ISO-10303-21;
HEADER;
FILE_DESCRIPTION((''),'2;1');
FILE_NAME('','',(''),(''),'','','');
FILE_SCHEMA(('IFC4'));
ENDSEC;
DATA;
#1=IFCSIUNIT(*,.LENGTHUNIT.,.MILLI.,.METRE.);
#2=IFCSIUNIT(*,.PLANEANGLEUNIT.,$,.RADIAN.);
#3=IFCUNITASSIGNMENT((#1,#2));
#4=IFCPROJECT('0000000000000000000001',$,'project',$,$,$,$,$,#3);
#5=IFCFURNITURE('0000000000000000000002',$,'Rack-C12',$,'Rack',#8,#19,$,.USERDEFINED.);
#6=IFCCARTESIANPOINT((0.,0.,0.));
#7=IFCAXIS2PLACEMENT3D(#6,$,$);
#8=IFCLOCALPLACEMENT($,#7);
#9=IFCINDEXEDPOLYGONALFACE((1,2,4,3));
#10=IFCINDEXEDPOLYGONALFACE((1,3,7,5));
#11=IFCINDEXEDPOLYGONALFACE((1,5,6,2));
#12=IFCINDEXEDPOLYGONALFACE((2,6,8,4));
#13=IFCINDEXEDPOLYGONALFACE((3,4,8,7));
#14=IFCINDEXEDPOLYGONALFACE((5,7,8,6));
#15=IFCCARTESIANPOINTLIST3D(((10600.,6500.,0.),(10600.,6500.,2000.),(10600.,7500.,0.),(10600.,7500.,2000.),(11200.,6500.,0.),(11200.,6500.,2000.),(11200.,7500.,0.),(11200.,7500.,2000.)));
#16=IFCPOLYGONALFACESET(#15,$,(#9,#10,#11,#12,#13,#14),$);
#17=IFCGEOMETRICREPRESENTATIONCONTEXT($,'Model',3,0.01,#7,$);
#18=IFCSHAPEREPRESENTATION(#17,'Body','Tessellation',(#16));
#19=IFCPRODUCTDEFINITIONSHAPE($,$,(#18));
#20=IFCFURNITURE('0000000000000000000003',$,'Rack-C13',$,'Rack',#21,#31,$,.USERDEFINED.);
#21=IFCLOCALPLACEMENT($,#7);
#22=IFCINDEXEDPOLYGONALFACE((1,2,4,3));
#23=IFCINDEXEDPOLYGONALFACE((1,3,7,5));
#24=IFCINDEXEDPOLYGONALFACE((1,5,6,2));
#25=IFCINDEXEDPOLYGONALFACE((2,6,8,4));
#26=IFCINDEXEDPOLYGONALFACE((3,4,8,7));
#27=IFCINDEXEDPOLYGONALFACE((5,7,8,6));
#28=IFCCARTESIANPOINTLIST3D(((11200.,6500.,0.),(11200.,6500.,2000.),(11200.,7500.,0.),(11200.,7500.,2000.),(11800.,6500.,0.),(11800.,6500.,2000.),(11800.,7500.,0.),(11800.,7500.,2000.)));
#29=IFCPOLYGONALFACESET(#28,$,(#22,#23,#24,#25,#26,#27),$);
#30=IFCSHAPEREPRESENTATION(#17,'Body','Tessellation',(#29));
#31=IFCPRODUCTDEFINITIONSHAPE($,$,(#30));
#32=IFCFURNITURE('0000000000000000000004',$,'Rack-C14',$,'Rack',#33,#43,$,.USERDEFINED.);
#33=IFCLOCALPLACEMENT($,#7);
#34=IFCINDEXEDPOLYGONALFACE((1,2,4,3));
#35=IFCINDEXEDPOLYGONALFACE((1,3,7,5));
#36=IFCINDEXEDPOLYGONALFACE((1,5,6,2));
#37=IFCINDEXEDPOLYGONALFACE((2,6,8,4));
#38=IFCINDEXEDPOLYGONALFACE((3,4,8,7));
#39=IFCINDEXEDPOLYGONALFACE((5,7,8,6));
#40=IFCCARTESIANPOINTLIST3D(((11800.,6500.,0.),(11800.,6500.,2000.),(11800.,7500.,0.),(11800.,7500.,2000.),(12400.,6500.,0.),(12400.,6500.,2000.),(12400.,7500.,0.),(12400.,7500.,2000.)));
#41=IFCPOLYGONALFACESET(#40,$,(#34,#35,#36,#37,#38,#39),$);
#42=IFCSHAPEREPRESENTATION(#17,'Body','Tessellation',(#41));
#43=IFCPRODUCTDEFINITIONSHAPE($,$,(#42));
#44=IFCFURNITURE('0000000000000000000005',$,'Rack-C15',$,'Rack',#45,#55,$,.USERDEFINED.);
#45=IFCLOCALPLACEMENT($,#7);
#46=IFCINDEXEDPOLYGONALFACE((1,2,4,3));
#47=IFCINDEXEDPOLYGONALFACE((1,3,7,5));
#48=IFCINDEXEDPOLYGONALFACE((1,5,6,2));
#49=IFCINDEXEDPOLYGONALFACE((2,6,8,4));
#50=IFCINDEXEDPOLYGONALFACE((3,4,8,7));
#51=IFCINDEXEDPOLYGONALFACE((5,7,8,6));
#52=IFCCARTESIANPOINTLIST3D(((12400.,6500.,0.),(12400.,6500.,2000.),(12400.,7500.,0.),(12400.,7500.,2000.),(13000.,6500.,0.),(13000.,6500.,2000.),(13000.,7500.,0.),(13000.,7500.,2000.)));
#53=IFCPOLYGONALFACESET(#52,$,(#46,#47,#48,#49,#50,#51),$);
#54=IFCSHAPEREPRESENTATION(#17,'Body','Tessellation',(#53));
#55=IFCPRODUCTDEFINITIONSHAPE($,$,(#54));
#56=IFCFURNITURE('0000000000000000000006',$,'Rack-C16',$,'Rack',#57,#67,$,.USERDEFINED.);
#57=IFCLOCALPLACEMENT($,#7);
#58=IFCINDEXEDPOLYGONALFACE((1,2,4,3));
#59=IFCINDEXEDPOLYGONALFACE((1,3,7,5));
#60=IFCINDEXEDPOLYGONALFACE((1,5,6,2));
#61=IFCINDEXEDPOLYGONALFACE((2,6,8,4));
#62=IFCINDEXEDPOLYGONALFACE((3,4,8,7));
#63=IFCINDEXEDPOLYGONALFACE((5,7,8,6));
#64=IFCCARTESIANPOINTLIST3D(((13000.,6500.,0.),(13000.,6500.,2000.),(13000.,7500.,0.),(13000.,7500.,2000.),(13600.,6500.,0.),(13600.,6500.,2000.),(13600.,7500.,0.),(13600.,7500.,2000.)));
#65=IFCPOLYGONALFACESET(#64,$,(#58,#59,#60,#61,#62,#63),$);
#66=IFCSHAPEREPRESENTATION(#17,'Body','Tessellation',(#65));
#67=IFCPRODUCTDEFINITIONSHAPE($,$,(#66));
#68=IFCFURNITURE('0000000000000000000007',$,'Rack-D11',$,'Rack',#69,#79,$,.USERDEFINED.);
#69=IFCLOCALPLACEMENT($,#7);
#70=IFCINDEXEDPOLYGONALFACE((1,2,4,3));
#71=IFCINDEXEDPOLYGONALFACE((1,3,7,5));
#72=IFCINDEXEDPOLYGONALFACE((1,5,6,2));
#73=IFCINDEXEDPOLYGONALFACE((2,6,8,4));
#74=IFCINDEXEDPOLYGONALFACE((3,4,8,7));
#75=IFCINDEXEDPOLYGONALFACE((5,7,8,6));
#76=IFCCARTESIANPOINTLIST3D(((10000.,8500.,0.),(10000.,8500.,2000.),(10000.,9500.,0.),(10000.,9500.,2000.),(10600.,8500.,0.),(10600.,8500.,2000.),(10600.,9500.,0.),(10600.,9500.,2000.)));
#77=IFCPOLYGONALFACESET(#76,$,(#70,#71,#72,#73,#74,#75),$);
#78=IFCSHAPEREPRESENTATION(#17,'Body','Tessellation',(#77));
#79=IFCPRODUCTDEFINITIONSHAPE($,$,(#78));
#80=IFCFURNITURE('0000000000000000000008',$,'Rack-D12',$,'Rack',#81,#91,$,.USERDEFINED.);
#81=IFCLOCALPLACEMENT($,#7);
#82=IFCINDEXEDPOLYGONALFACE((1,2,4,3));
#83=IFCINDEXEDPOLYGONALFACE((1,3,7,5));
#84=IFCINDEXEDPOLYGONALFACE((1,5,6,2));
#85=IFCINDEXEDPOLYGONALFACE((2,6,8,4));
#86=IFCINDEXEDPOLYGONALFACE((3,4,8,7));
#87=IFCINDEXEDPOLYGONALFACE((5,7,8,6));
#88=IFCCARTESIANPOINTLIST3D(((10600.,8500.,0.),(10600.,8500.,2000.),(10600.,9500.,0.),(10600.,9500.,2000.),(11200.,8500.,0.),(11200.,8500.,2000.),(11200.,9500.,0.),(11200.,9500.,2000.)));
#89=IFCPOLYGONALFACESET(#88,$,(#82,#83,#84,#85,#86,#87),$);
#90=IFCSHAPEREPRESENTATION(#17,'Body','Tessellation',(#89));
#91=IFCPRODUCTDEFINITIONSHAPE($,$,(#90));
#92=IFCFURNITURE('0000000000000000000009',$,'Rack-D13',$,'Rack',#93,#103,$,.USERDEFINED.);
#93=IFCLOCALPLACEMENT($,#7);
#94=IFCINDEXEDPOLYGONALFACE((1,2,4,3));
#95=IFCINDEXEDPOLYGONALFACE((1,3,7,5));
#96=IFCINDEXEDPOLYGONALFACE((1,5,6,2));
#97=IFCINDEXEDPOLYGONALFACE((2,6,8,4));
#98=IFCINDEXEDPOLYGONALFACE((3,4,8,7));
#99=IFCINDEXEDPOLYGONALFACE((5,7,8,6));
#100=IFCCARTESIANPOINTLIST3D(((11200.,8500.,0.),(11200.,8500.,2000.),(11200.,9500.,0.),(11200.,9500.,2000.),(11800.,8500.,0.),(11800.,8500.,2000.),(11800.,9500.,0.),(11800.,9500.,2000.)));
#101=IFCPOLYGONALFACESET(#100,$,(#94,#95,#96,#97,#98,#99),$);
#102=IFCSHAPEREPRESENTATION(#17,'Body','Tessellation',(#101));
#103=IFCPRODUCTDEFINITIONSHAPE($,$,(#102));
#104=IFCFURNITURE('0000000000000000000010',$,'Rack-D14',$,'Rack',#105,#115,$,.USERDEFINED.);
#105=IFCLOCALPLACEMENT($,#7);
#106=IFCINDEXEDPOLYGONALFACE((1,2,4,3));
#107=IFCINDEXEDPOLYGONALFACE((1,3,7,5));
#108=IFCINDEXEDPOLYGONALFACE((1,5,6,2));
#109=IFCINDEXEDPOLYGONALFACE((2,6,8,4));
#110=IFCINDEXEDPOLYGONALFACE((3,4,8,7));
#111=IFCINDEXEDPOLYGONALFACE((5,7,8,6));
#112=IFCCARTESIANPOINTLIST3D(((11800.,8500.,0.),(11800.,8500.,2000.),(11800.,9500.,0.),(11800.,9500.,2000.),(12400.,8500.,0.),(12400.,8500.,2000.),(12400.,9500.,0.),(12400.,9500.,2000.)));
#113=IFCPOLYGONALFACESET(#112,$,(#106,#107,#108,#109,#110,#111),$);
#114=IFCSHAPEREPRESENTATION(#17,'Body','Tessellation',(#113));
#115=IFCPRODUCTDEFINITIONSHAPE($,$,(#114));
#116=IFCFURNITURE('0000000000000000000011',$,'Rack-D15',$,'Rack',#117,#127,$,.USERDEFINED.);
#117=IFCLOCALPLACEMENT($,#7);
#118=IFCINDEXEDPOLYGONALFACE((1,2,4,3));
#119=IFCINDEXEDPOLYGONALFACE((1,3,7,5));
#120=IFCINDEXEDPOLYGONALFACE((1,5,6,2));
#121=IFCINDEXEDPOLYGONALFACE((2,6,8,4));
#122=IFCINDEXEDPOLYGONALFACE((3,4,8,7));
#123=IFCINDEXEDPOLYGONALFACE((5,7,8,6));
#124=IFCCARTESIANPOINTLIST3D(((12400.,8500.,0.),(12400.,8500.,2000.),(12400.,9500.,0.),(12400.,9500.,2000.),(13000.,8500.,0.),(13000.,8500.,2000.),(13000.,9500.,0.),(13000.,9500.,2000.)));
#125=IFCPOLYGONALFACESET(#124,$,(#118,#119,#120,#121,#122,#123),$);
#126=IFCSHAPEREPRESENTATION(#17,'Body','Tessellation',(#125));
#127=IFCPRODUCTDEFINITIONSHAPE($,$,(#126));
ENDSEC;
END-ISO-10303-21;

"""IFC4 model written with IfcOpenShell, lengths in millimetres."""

from ifc_helpers import new_model, si_unit, frame, origin, place, context, project, polyline, outline, extrude, element, save


model = new_model("IFC4")

# Units and contexts
model_context = context("Model", 3, precision=0.01, world=origin())
ifc_project = project(units=[si_unit("LENGTHUNIT", "METRE", prefix="MILLI"), si_unit("PLANEANGLEUNIT", "RADIAN")])

# Furniture
for number, where, name in (
    (1, (10900.0, 7000.0, 0.0), "Rack-C12"),
    (2, (11500.0, 7000.0, 0.0), "Rack-C13"),
    (3, (12100.0, 7000.0, 0.0), "Rack-C14"),
    (4, (12700.0, 7000.0, 0.0), "Rack-C15"),
    (5, (13300.0, 7000.0, 0.0), "Rack-C16"),
    (6, (10300.0, 9000.0, 0.0), "Rack-D11"),
    (7, (10900.0, 9000.0, 0.0), "Rack-D12"),
    (8, (11500.0, 9000.0, 0.0), "Rack-D13"),
    (9, (12100.0, 9000.0, 0.0), "Rack-D14"),
    (10, (12700.0, 9000.0, 0.0), "Rack-D15"),
):
    element("IfcFurniture", number, at=place(None, frame(where)), Name=name, ObjectType="Rack", PredefinedType="USERDEFINED", context=model_context, shape_type="SweptSolid", body=[
        extrude(outline(polyline([(-300.0, -500.0), (300.0, -500.0), (300.0, 500.0), (-300.0, 500.0), (-300.0, -500.0)])), origin(), (0.0, 0.0, 1.0), 2000.0),
    ])

save(model, "model.ifc")
